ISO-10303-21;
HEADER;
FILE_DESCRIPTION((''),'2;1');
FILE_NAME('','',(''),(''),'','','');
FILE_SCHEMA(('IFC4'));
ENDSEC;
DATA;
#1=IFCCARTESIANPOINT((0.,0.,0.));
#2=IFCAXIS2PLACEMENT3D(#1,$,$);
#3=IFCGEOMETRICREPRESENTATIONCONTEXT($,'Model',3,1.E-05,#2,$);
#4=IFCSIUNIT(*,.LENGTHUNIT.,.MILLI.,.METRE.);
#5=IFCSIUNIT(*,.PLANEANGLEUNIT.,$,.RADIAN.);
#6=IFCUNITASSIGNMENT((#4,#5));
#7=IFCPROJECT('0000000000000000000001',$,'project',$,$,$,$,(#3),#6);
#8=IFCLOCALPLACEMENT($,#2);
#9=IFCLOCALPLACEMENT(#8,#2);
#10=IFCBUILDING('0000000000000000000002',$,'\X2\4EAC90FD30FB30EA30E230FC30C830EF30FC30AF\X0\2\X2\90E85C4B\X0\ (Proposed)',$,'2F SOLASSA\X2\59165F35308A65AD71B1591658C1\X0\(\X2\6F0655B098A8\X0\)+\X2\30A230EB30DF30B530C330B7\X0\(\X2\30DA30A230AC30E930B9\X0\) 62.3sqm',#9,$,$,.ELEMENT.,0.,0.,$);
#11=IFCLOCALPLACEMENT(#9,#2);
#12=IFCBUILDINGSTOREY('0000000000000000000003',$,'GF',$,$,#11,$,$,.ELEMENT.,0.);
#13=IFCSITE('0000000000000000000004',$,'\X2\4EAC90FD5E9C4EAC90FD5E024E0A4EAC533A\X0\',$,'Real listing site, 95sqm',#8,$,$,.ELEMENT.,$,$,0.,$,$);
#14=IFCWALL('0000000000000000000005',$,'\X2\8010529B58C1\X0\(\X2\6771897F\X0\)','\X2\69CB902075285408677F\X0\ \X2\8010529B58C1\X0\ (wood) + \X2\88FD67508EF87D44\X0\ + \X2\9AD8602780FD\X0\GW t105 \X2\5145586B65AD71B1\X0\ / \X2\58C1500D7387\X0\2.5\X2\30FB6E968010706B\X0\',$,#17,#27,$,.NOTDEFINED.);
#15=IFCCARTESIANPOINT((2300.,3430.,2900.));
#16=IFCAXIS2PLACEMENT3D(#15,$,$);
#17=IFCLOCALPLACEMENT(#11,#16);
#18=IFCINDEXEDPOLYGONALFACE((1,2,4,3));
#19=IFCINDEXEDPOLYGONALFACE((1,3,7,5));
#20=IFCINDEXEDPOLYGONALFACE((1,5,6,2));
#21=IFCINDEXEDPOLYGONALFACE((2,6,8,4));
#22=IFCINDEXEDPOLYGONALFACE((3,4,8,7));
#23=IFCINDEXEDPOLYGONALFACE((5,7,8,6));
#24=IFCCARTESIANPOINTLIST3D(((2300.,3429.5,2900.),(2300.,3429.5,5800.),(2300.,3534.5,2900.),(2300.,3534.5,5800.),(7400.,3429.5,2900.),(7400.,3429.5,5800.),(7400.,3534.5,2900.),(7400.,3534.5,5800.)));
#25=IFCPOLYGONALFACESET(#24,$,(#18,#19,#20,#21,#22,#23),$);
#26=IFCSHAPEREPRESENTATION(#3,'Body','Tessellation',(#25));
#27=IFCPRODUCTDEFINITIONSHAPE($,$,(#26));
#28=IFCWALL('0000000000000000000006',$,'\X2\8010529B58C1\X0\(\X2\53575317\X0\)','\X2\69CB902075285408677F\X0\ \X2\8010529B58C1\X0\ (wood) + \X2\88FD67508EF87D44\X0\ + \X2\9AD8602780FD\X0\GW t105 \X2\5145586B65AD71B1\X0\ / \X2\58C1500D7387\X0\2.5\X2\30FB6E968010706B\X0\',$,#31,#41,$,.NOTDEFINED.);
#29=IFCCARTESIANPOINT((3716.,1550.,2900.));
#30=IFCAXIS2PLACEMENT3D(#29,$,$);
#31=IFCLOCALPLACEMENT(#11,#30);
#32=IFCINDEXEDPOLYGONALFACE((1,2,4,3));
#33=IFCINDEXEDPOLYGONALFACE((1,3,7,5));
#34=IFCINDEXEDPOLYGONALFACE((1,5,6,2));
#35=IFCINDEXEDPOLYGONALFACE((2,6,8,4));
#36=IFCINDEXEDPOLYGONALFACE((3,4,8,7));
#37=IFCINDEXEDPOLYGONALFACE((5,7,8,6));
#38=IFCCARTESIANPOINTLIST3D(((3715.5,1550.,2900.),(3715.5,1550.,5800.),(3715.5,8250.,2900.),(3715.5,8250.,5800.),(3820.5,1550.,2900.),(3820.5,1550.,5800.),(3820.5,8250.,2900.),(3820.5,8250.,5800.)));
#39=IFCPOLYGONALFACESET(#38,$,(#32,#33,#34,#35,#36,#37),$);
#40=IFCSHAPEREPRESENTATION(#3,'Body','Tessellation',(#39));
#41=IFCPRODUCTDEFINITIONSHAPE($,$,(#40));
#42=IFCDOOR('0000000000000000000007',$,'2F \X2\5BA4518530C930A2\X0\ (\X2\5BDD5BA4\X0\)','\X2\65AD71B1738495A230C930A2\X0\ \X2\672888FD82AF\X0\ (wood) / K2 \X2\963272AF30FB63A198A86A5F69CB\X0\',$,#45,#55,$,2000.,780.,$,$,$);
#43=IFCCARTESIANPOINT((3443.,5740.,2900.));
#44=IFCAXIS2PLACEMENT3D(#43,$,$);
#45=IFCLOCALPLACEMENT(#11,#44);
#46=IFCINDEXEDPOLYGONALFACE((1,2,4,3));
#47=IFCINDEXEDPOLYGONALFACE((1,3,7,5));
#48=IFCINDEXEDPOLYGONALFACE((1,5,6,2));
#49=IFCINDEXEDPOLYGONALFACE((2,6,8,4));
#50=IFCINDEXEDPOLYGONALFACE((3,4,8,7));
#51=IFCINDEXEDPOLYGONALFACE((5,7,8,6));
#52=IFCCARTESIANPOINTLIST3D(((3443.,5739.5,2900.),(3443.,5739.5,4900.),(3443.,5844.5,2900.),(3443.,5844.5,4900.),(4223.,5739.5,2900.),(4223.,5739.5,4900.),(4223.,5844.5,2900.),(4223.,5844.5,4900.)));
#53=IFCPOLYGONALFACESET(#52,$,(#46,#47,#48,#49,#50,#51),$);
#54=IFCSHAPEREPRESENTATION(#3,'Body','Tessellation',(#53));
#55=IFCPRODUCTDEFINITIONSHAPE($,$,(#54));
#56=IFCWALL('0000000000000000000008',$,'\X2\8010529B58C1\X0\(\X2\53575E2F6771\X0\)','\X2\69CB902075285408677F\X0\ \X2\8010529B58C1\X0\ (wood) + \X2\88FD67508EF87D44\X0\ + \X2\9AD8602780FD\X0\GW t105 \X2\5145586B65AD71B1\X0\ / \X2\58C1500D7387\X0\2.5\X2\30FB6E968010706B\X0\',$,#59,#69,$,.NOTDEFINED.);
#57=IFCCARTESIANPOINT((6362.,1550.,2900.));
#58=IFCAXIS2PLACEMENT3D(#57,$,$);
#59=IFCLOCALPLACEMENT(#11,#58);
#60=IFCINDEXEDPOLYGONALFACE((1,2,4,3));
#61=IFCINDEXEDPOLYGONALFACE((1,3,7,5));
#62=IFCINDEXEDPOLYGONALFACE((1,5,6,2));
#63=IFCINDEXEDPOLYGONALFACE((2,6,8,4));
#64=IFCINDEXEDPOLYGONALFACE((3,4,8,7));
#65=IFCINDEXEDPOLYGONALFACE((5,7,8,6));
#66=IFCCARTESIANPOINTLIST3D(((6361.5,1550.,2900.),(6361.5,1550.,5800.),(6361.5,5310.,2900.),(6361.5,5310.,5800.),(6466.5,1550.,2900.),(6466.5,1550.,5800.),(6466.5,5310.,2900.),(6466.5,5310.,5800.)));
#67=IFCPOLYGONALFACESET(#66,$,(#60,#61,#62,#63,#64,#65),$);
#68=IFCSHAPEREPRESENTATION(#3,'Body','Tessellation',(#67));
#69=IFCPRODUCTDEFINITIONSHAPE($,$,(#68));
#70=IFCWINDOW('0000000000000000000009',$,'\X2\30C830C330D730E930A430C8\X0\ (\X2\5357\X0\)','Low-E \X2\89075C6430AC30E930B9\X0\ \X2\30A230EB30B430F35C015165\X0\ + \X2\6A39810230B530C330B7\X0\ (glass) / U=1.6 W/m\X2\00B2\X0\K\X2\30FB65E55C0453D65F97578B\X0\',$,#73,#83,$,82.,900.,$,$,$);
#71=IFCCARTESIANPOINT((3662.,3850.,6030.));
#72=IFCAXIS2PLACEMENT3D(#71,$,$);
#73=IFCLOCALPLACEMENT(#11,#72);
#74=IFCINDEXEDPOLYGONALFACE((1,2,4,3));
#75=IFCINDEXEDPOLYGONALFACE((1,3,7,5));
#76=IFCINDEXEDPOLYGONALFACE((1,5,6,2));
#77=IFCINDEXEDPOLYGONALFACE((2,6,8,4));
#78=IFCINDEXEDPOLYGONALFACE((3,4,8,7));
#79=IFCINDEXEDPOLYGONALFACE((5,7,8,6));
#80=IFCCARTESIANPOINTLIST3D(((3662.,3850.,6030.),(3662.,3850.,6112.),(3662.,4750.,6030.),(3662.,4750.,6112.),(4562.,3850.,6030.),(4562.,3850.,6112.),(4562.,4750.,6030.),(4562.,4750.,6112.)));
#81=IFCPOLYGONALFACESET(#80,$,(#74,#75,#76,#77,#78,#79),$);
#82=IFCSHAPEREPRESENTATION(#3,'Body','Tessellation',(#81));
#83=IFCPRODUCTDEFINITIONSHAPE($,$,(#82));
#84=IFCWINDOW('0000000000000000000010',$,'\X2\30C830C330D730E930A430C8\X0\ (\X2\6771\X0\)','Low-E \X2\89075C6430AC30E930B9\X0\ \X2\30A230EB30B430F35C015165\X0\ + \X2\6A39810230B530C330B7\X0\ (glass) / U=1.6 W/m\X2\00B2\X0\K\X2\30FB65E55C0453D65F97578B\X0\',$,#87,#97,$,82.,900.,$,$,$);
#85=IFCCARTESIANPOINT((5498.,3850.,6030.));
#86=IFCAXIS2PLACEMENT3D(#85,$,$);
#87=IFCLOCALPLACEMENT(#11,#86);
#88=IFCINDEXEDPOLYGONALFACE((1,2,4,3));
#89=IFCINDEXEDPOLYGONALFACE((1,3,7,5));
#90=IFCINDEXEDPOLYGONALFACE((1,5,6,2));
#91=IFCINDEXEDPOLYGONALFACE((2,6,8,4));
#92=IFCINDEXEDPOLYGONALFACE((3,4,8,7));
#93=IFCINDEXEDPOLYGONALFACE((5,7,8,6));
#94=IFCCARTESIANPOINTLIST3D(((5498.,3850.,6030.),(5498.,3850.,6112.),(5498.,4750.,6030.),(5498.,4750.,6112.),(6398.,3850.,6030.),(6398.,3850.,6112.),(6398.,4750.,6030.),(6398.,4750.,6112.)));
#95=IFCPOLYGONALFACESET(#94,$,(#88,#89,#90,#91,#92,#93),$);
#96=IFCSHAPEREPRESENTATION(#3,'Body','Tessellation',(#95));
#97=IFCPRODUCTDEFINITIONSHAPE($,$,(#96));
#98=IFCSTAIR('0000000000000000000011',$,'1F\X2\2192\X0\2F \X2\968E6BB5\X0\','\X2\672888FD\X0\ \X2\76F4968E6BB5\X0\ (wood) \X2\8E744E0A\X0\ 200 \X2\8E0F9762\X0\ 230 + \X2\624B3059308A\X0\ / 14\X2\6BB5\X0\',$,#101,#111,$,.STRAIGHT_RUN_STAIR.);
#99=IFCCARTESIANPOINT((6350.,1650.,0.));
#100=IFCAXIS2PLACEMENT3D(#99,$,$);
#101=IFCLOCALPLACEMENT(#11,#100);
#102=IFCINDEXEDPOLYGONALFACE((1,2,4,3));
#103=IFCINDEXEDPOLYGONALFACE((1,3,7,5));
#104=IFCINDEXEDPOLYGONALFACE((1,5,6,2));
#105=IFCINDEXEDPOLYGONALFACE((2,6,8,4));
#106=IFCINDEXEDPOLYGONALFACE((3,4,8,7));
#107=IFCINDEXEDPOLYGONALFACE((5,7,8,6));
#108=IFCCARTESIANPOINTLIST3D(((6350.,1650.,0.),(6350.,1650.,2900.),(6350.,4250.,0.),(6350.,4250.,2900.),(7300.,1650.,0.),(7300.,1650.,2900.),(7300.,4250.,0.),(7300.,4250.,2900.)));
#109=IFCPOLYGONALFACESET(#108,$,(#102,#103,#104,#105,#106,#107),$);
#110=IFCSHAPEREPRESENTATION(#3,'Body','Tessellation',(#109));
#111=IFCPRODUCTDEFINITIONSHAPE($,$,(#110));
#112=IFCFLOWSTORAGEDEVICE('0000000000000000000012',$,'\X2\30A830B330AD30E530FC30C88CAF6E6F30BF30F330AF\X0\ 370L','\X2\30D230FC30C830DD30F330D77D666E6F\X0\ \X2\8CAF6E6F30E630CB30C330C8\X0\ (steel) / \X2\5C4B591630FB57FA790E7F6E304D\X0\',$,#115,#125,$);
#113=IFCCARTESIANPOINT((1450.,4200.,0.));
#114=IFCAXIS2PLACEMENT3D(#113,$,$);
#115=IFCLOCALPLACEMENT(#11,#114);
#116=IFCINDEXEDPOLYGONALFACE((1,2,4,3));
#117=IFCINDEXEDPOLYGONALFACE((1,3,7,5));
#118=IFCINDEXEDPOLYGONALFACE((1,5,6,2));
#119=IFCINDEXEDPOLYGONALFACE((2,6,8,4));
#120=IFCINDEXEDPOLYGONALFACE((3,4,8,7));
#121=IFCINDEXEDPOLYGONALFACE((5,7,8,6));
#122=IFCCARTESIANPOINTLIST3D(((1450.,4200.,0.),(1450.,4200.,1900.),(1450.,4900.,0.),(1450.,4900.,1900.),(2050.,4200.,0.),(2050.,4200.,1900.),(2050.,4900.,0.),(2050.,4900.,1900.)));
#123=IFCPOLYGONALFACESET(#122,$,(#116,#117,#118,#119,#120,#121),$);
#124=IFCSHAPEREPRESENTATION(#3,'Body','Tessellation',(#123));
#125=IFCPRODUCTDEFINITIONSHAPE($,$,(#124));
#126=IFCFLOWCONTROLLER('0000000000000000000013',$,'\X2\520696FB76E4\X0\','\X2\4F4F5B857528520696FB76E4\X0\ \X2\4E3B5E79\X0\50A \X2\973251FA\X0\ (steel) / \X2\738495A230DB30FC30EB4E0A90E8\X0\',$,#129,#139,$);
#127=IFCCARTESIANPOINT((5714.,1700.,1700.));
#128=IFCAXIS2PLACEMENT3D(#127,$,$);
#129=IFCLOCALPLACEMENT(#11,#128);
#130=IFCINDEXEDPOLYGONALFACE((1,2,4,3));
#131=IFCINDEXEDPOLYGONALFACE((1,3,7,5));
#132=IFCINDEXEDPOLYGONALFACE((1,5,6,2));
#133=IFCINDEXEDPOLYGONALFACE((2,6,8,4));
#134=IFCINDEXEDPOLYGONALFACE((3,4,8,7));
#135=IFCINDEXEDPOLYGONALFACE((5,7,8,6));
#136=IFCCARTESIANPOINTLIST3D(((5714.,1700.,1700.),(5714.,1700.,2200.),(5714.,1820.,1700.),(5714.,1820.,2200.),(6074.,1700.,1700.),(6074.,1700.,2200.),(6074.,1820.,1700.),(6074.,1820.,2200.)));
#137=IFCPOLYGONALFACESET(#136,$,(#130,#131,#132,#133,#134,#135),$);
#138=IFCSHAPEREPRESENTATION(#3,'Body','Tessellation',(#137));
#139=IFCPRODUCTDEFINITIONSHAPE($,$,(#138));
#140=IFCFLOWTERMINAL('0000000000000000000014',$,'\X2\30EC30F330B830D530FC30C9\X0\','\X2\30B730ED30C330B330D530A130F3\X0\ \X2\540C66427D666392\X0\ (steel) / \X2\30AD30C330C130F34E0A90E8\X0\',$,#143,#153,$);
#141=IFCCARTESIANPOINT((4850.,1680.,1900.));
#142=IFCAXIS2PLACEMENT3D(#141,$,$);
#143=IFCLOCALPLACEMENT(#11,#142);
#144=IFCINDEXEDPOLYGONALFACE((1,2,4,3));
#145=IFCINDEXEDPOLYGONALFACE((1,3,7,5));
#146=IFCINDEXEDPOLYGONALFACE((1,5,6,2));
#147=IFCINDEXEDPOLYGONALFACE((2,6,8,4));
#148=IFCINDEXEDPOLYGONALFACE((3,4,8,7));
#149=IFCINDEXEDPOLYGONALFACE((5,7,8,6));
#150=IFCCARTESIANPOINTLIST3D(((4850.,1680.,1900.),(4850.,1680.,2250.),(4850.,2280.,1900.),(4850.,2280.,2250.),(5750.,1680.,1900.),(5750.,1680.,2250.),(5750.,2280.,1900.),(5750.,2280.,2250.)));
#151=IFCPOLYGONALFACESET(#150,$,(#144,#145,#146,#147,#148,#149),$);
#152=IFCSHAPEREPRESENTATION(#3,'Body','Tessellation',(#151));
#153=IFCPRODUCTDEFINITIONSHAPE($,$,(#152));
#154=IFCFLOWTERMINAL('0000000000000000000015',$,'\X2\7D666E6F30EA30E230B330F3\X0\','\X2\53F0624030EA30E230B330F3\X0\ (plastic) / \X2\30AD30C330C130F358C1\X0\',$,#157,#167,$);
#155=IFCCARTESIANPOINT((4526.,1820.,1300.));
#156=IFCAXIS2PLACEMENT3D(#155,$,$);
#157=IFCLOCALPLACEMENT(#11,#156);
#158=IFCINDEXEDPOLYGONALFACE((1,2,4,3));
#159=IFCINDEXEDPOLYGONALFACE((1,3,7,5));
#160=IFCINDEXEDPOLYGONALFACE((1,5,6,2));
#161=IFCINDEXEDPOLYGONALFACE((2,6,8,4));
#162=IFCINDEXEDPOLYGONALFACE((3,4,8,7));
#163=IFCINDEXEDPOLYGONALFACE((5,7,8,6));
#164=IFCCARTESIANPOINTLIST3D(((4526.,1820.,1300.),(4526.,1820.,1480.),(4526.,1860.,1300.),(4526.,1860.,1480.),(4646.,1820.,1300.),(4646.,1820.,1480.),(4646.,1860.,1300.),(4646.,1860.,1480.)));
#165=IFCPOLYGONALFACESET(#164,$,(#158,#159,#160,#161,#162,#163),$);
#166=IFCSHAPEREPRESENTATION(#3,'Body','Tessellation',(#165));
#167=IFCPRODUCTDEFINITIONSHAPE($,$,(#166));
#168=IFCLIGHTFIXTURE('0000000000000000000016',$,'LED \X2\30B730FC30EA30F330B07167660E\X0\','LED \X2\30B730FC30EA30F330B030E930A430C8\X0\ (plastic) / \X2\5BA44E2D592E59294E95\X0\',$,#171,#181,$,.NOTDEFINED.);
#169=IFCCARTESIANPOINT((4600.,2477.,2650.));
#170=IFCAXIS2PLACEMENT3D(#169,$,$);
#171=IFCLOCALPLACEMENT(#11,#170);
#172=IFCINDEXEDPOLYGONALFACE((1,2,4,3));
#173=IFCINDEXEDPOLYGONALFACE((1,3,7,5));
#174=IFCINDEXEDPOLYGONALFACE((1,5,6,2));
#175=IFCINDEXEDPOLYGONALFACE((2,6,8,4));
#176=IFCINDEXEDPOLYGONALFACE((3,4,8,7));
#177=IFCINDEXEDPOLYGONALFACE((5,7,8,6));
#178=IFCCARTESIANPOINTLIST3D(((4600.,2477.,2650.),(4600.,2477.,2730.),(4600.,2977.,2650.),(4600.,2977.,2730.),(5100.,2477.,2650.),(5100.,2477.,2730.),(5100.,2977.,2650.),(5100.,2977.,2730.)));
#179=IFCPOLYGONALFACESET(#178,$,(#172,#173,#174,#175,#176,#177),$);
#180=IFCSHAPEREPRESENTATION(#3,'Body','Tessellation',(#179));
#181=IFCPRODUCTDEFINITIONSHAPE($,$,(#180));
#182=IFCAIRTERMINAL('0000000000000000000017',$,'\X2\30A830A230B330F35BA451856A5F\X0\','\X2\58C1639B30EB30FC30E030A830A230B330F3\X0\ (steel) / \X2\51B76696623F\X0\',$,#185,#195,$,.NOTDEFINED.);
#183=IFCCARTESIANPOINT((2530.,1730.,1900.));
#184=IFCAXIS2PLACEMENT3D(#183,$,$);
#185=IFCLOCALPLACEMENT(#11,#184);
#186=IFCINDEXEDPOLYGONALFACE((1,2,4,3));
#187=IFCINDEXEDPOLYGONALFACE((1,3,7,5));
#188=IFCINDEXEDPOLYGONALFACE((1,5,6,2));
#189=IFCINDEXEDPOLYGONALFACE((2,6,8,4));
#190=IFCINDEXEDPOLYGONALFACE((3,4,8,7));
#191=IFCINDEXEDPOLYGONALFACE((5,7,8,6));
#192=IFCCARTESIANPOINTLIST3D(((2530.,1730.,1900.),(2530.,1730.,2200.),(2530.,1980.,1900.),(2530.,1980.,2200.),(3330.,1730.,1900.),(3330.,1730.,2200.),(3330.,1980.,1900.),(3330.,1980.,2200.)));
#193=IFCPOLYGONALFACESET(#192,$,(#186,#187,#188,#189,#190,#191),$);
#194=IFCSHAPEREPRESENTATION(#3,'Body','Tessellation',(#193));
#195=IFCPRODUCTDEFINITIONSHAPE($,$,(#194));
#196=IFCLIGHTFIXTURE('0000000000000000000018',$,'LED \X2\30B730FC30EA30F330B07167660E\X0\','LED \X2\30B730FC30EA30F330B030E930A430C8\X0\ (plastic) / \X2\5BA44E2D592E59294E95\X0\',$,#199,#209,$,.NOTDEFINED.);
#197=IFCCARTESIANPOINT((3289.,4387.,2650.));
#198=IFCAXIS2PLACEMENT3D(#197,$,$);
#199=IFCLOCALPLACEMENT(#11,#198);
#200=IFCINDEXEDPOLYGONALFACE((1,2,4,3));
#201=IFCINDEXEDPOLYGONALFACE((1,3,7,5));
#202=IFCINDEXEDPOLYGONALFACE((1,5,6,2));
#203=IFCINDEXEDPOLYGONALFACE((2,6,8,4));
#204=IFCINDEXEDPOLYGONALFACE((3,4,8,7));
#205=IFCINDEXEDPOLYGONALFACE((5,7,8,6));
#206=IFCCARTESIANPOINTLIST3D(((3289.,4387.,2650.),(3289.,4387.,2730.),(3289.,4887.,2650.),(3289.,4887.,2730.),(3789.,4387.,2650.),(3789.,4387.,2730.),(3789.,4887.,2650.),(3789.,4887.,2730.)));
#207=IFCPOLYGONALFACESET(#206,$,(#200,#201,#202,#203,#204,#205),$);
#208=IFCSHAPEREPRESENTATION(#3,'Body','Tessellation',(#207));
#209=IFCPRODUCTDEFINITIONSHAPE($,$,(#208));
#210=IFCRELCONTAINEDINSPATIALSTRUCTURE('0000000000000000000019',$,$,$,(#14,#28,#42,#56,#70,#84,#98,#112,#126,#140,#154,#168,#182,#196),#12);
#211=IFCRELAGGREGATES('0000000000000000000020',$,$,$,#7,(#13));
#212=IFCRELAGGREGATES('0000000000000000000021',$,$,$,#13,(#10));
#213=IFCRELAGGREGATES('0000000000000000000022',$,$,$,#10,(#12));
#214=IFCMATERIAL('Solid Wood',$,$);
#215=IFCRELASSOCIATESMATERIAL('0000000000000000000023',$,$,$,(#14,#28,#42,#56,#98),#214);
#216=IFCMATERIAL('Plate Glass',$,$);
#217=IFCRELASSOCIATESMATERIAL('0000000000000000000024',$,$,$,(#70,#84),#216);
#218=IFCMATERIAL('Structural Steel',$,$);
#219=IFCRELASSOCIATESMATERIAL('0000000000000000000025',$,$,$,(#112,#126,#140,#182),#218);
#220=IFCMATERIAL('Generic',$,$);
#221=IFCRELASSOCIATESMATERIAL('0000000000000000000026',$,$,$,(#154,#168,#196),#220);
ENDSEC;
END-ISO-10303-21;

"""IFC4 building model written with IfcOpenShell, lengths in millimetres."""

from ifc_helpers import new_model, si_unit, frame, frame_2d, origin, place, context, project, spatial, rectangle, extrude, material, element, fill, save


model = new_model("IFC4")

# Units and contexts
model_context = context("Model", 3, precision=1e-05, world=origin())
ifc_project = project(units=[si_unit("LENGTHUNIT", "METRE", prefix="MILLI"), si_unit("PLANEANGLEUNIT", "RADIAN")], contexts=[model_context])

# Site, building, storey
site_placement = place(None, origin())
site = spatial("IfcSite", under=ifc_project, at=site_placement, Name="京都府京都市上京区", ObjectType="Real listing site, 95sqm", CompositionType="ELEMENT", RefElevation=0.0)
building_placement = place(site_placement, origin())
building = spatial("IfcBuilding", under=site, at=building_placement, Name="京都・リモートワーク2部屋 (Proposed)", ObjectType="2F SOLASSA外張り断熱外壁(漆喰風)+アルミサッシ(ペアガラス) 62.3sqm", CompositionType="ELEMENT", ElevationOfRefHeight=0.0, ElevationOfTerrain=0.0)
storey_placement = place(building_placement, origin())
storey = spatial("IfcBuildingStorey", under=building, at=storey_placement, Name="GF", CompositionType="ELEMENT", Elevation=0.0)

# Shared definitions
ifc_material_1 = material(Name="Solid Wood")

# Wall
wall_1_placement = place(storey_placement, frame((2300.0, 3430.0, 2900.0)))
element("IfcWall", 1, at=wall_1_placement, inside=storey, material=ifc_material_1, Name="耐力壁(東西)", Description="構造用合板 耐力壁 (wood) + 製材軸組 + 高性能GW t105 充填断熱 / 壁倍率2.5・準耐火", PredefinedType="NOTDEFINED", context=model_context, shape_type="SweptSolid", body=[
    extrude(rectangle(XDim=5100.0, YDim=105.0, at=frame_2d((2550.0, 52.0))), frame((2300.0, 3430.0, 2900.0)), (0.0, 0.0, 1.0), 2900.0),
])

# Wall, opening, door
wall_2_placement = place(storey_placement, frame((3716.0, 1550.0, 2900.0)))
wall_2 = element("IfcWall", 2, at=wall_2_placement, inside=storey, material=ifc_material_1, Name="耐力壁(南北)", Description="構造用合板 耐力壁 (wood) + 製材軸組 + 高性能GW t105 充填断熱 / 壁倍率2.5・準耐火", PredefinedType="NOTDEFINED", context=model_context, shape_type="SweptSolid", body=[
    extrude(rectangle(XDim=105.0, YDim=6700.0, at=frame_2d((52.0, 3350.0))), frame((3716.0, 1550.0, 2900.0)), (0.0, 0.0, 1.0), 2900.0),
])
opening_placement = place(storey_placement, frame((3443.0, 5740.0, 2900.0)))
opening = element("IfcOpeningElement", 3, at=opening_placement, cuts=wall_2, PredefinedType="NOTDEFINED", context=model_context, shape_type="SweptSolid", body=[
    extrude(rectangle(XDim=780.0, YDim=105.0, at=frame_2d((390.0, 52.0))), frame((3443.0, 5740.0, 2900.0)), (0.0, 0.0, 1.0), 2000.0),
])
door_placement = place(storey_placement, frame((3443.0, 5740.0, 2900.0)))
door = element("IfcDoor", 4, at=door_placement, inside=storey, material=ifc_material_1, Name="2F 室内ドア (寝室)", Description="断熱玄関ドア 木製芯 (wood) / K2 防犯・採風機構", OverallHeight=2000.0, OverallWidth=780.0, context=model_context, shape_type="SweptSolid", body=[
    extrude(rectangle(XDim=780.0, YDim=105.0, at=frame_2d((390.0, 52.0))), frame((3443.0, 5740.0, 2900.0)), (0.0, 0.0, 1.0), 2000.0),
])
fill(opening, door)

# Wall
wall_3_placement = place(storey_placement, frame((6362.0, 1550.0, 2900.0)))
element("IfcWall", 5, at=wall_3_placement, inside=storey, material=ifc_material_1, Name="耐力壁(南帯東)", Description="構造用合板 耐力壁 (wood) + 製材軸組 + 高性能GW t105 充填断熱 / 壁倍率2.5・準耐火", PredefinedType="NOTDEFINED", context=model_context, shape_type="SweptSolid", body=[
    extrude(rectangle(XDim=105.0, YDim=3760.0, at=frame_2d((52.0, 1880.0))), frame((6362.0, 1550.0, 2900.0)), (0.0, 0.0, 1.0), 2900.0),
])

# Windows
ifc_material_2 = material(Name="Plate Glass")
window_1_placement = place(storey_placement, frame((3662.0, 3850.0, 6030.0)))
element("IfcWindow", 6, at=window_1_placement, inside=storey, material=ifc_material_2, Name="トップライト (南)", Description="Low-E 複層ガラス アルゴン封入 + 樹脂サッシ (glass) / U=1.6 W/m²K・日射取得型", OverallHeight=82.0, OverallWidth=900.0, context=model_context, shape_type="SweptSolid", body=[
    extrude(rectangle(XDim=900.0, YDim=900.0, at=frame_2d((450.0, 450.0))), frame((3662.0, 3850.0, 6030.0)), (0.0, 0.0, 1.0), 82.0),
])
window_2_placement = place(storey_placement, frame((5498.0, 3850.0, 6030.0)))
element("IfcWindow", 7, at=window_2_placement, inside=storey, material=ifc_material_2, Name="トップライト (東)", Description="Low-E 複層ガラス アルゴン封入 + 樹脂サッシ (glass) / U=1.6 W/m²K・日射取得型", OverallHeight=82.0, OverallWidth=900.0, context=model_context, shape_type="SweptSolid", body=[
    extrude(rectangle(XDim=900.0, YDim=900.0, at=frame_2d((450.0, 450.0))), frame((5498.0, 3850.0, 6030.0)), (0.0, 0.0, 1.0), 82.0),
])

# Stair
stair_placement = place(storey_placement, frame((6350.0, 1650.0, 0.0)))
element("IfcStair", 8, at=stair_placement, inside=storey, material=ifc_material_1, Name="1F→2F 階段", Description="木製 直階段 (wood) 蹴上 200 踏面 230 + 手すり / 14段", PredefinedType="STRAIGHT_RUN_STAIR", context=model_context, shape_type="SweptSolid", body=[
    extrude(rectangle(XDim=950.0, YDim=2600.0, at=frame_2d((475.0, 1300.0))), frame((6350.0, 1650.0, 0.0)), (0.0, 0.0, 1.0), 2900.0),
])

# Flow storage device
ifc_material_3 = material(Name="Structural Steel")
flow_storage_device_placement = place(storey_placement, frame((1450.0, 4200.0, 0.0)))
element("IfcFlowStorageDevice", 9, at=flow_storage_device_placement, inside=storey, material=ifc_material_3, Name="エコキュート貯湯タンク 370L", Description="ヒートポンプ給湯 貯湯ユニット (steel) / 屋外・基礎置き", context=model_context, shape_type="SweptSolid", body=[
    extrude(rectangle(XDim=600.0, YDim=700.0, at=frame_2d((300.0, 350.0))), frame((1450.0, 4200.0, 0.0)), (0.0, 0.0, 1.0), 1900.0),
])

# Flow controller
flow_controller_placement = place(storey_placement, frame((5714.0, 1700.0, 1700.0)))
element("IfcFlowController", 10, at=flow_controller_placement, inside=storey, material=ifc_material_3, Name="分電盤", Description="住宅用分電盤 主幹50A 露出 (steel) / 玄関ホール上部", context=model_context, shape_type="SweptSolid", body=[
    extrude(rectangle(XDim=360.0, YDim=120.0, at=frame_2d((180.0, 60.0))), frame((5714.0, 1700.0, 1700.0)), (0.0, 0.0, 1.0), 500.0),
])

# Flow terminals
flow_terminal_1_placement = place(storey_placement, frame((4850.0, 1680.0, 1900.0)))
element("IfcFlowTerminal", 11, at=flow_terminal_1_placement, inside=storey, material=ifc_material_3, Name="レンジフード", Description="シロッコファン 同時給排 (steel) / キッチン上部", context=model_context, shape_type="SweptSolid", body=[
    extrude(rectangle(XDim=900.0, YDim=600.0, at=frame_2d((450.0, 300.0))), frame((4850.0, 1680.0, 1900.0)), (0.0, 0.0, 1.0), 350.0),
])
ifc_material_4 = material(Name="Generic")
flow_terminal_2_placement = place(storey_placement, frame((4526.0, 1820.0, 1300.0)))
element("IfcFlowTerminal", 12, at=flow_terminal_2_placement, inside=storey, material=ifc_material_4, Name="給湯リモコン", Description="台所リモコン (plastic) / キッチン壁", context=model_context, shape_type="SweptSolid", body=[
    extrude(rectangle(XDim=120.0, YDim=40.0, at=frame_2d((60.0, 20.0))), frame((4526.0, 1820.0, 1300.0)), (0.0, 0.0, 1.0), 180.0),
])

# Light fixture
light_fixture_1_placement = place(storey_placement, frame((4600.0, 2477.0, 2650.0)))
element("IfcLightFixture", 13, at=light_fixture_1_placement, inside=storey, material=ifc_material_4, Name="LED シーリング照明", Description="LED シーリングライト (plastic) / 室中央天井", PredefinedType="NOTDEFINED", context=model_context, shape_type="SweptSolid", body=[
    extrude(rectangle(XDim=500.0, YDim=500.0, at=frame_2d((250.0, 250.0))), frame((4600.0, 2477.0, 2650.0)), (0.0, 0.0, 1.0), 80.0),
])

# Air terminal
air_terminal_1_placement = place(storey_placement, frame((2530.0, 1730.0, 1900.0)))
element("IfcAirTerminal", 14, at=air_terminal_1_placement, inside=storey, material=ifc_material_3, Name="エアコン室内機", Description="壁掛ルームエアコン (steel) / 冷暖房", PredefinedType="NOTDEFINED", context=model_context, shape_type="SweptSolid", body=[
    extrude(rectangle(XDim=800.0, YDim=250.0, at=frame_2d((400.0, 125.0))), frame((2530.0, 1730.0, 1900.0)), (0.0, 0.0, 1.0), 300.0),
])

# Light fixture
light_fixture_2_placement = place(storey_placement, frame((3289.0, 4387.0, 2650.0)))
element("IfcLightFixture", 15, at=light_fixture_2_placement, inside=storey, material=ifc_material_4, Name="LED シーリング照明", Description="LED シーリングライト (plastic) / 室中央天井", PredefinedType="NOTDEFINED", context=model_context, shape_type="SweptSolid", body=[
    extrude(rectangle(XDim=500.0, YDim=500.0, at=frame_2d((250.0, 250.0))), frame((3289.0, 4387.0, 2650.0)), (0.0, 0.0, 1.0), 80.0),
])

save(model, "model.ifc")
